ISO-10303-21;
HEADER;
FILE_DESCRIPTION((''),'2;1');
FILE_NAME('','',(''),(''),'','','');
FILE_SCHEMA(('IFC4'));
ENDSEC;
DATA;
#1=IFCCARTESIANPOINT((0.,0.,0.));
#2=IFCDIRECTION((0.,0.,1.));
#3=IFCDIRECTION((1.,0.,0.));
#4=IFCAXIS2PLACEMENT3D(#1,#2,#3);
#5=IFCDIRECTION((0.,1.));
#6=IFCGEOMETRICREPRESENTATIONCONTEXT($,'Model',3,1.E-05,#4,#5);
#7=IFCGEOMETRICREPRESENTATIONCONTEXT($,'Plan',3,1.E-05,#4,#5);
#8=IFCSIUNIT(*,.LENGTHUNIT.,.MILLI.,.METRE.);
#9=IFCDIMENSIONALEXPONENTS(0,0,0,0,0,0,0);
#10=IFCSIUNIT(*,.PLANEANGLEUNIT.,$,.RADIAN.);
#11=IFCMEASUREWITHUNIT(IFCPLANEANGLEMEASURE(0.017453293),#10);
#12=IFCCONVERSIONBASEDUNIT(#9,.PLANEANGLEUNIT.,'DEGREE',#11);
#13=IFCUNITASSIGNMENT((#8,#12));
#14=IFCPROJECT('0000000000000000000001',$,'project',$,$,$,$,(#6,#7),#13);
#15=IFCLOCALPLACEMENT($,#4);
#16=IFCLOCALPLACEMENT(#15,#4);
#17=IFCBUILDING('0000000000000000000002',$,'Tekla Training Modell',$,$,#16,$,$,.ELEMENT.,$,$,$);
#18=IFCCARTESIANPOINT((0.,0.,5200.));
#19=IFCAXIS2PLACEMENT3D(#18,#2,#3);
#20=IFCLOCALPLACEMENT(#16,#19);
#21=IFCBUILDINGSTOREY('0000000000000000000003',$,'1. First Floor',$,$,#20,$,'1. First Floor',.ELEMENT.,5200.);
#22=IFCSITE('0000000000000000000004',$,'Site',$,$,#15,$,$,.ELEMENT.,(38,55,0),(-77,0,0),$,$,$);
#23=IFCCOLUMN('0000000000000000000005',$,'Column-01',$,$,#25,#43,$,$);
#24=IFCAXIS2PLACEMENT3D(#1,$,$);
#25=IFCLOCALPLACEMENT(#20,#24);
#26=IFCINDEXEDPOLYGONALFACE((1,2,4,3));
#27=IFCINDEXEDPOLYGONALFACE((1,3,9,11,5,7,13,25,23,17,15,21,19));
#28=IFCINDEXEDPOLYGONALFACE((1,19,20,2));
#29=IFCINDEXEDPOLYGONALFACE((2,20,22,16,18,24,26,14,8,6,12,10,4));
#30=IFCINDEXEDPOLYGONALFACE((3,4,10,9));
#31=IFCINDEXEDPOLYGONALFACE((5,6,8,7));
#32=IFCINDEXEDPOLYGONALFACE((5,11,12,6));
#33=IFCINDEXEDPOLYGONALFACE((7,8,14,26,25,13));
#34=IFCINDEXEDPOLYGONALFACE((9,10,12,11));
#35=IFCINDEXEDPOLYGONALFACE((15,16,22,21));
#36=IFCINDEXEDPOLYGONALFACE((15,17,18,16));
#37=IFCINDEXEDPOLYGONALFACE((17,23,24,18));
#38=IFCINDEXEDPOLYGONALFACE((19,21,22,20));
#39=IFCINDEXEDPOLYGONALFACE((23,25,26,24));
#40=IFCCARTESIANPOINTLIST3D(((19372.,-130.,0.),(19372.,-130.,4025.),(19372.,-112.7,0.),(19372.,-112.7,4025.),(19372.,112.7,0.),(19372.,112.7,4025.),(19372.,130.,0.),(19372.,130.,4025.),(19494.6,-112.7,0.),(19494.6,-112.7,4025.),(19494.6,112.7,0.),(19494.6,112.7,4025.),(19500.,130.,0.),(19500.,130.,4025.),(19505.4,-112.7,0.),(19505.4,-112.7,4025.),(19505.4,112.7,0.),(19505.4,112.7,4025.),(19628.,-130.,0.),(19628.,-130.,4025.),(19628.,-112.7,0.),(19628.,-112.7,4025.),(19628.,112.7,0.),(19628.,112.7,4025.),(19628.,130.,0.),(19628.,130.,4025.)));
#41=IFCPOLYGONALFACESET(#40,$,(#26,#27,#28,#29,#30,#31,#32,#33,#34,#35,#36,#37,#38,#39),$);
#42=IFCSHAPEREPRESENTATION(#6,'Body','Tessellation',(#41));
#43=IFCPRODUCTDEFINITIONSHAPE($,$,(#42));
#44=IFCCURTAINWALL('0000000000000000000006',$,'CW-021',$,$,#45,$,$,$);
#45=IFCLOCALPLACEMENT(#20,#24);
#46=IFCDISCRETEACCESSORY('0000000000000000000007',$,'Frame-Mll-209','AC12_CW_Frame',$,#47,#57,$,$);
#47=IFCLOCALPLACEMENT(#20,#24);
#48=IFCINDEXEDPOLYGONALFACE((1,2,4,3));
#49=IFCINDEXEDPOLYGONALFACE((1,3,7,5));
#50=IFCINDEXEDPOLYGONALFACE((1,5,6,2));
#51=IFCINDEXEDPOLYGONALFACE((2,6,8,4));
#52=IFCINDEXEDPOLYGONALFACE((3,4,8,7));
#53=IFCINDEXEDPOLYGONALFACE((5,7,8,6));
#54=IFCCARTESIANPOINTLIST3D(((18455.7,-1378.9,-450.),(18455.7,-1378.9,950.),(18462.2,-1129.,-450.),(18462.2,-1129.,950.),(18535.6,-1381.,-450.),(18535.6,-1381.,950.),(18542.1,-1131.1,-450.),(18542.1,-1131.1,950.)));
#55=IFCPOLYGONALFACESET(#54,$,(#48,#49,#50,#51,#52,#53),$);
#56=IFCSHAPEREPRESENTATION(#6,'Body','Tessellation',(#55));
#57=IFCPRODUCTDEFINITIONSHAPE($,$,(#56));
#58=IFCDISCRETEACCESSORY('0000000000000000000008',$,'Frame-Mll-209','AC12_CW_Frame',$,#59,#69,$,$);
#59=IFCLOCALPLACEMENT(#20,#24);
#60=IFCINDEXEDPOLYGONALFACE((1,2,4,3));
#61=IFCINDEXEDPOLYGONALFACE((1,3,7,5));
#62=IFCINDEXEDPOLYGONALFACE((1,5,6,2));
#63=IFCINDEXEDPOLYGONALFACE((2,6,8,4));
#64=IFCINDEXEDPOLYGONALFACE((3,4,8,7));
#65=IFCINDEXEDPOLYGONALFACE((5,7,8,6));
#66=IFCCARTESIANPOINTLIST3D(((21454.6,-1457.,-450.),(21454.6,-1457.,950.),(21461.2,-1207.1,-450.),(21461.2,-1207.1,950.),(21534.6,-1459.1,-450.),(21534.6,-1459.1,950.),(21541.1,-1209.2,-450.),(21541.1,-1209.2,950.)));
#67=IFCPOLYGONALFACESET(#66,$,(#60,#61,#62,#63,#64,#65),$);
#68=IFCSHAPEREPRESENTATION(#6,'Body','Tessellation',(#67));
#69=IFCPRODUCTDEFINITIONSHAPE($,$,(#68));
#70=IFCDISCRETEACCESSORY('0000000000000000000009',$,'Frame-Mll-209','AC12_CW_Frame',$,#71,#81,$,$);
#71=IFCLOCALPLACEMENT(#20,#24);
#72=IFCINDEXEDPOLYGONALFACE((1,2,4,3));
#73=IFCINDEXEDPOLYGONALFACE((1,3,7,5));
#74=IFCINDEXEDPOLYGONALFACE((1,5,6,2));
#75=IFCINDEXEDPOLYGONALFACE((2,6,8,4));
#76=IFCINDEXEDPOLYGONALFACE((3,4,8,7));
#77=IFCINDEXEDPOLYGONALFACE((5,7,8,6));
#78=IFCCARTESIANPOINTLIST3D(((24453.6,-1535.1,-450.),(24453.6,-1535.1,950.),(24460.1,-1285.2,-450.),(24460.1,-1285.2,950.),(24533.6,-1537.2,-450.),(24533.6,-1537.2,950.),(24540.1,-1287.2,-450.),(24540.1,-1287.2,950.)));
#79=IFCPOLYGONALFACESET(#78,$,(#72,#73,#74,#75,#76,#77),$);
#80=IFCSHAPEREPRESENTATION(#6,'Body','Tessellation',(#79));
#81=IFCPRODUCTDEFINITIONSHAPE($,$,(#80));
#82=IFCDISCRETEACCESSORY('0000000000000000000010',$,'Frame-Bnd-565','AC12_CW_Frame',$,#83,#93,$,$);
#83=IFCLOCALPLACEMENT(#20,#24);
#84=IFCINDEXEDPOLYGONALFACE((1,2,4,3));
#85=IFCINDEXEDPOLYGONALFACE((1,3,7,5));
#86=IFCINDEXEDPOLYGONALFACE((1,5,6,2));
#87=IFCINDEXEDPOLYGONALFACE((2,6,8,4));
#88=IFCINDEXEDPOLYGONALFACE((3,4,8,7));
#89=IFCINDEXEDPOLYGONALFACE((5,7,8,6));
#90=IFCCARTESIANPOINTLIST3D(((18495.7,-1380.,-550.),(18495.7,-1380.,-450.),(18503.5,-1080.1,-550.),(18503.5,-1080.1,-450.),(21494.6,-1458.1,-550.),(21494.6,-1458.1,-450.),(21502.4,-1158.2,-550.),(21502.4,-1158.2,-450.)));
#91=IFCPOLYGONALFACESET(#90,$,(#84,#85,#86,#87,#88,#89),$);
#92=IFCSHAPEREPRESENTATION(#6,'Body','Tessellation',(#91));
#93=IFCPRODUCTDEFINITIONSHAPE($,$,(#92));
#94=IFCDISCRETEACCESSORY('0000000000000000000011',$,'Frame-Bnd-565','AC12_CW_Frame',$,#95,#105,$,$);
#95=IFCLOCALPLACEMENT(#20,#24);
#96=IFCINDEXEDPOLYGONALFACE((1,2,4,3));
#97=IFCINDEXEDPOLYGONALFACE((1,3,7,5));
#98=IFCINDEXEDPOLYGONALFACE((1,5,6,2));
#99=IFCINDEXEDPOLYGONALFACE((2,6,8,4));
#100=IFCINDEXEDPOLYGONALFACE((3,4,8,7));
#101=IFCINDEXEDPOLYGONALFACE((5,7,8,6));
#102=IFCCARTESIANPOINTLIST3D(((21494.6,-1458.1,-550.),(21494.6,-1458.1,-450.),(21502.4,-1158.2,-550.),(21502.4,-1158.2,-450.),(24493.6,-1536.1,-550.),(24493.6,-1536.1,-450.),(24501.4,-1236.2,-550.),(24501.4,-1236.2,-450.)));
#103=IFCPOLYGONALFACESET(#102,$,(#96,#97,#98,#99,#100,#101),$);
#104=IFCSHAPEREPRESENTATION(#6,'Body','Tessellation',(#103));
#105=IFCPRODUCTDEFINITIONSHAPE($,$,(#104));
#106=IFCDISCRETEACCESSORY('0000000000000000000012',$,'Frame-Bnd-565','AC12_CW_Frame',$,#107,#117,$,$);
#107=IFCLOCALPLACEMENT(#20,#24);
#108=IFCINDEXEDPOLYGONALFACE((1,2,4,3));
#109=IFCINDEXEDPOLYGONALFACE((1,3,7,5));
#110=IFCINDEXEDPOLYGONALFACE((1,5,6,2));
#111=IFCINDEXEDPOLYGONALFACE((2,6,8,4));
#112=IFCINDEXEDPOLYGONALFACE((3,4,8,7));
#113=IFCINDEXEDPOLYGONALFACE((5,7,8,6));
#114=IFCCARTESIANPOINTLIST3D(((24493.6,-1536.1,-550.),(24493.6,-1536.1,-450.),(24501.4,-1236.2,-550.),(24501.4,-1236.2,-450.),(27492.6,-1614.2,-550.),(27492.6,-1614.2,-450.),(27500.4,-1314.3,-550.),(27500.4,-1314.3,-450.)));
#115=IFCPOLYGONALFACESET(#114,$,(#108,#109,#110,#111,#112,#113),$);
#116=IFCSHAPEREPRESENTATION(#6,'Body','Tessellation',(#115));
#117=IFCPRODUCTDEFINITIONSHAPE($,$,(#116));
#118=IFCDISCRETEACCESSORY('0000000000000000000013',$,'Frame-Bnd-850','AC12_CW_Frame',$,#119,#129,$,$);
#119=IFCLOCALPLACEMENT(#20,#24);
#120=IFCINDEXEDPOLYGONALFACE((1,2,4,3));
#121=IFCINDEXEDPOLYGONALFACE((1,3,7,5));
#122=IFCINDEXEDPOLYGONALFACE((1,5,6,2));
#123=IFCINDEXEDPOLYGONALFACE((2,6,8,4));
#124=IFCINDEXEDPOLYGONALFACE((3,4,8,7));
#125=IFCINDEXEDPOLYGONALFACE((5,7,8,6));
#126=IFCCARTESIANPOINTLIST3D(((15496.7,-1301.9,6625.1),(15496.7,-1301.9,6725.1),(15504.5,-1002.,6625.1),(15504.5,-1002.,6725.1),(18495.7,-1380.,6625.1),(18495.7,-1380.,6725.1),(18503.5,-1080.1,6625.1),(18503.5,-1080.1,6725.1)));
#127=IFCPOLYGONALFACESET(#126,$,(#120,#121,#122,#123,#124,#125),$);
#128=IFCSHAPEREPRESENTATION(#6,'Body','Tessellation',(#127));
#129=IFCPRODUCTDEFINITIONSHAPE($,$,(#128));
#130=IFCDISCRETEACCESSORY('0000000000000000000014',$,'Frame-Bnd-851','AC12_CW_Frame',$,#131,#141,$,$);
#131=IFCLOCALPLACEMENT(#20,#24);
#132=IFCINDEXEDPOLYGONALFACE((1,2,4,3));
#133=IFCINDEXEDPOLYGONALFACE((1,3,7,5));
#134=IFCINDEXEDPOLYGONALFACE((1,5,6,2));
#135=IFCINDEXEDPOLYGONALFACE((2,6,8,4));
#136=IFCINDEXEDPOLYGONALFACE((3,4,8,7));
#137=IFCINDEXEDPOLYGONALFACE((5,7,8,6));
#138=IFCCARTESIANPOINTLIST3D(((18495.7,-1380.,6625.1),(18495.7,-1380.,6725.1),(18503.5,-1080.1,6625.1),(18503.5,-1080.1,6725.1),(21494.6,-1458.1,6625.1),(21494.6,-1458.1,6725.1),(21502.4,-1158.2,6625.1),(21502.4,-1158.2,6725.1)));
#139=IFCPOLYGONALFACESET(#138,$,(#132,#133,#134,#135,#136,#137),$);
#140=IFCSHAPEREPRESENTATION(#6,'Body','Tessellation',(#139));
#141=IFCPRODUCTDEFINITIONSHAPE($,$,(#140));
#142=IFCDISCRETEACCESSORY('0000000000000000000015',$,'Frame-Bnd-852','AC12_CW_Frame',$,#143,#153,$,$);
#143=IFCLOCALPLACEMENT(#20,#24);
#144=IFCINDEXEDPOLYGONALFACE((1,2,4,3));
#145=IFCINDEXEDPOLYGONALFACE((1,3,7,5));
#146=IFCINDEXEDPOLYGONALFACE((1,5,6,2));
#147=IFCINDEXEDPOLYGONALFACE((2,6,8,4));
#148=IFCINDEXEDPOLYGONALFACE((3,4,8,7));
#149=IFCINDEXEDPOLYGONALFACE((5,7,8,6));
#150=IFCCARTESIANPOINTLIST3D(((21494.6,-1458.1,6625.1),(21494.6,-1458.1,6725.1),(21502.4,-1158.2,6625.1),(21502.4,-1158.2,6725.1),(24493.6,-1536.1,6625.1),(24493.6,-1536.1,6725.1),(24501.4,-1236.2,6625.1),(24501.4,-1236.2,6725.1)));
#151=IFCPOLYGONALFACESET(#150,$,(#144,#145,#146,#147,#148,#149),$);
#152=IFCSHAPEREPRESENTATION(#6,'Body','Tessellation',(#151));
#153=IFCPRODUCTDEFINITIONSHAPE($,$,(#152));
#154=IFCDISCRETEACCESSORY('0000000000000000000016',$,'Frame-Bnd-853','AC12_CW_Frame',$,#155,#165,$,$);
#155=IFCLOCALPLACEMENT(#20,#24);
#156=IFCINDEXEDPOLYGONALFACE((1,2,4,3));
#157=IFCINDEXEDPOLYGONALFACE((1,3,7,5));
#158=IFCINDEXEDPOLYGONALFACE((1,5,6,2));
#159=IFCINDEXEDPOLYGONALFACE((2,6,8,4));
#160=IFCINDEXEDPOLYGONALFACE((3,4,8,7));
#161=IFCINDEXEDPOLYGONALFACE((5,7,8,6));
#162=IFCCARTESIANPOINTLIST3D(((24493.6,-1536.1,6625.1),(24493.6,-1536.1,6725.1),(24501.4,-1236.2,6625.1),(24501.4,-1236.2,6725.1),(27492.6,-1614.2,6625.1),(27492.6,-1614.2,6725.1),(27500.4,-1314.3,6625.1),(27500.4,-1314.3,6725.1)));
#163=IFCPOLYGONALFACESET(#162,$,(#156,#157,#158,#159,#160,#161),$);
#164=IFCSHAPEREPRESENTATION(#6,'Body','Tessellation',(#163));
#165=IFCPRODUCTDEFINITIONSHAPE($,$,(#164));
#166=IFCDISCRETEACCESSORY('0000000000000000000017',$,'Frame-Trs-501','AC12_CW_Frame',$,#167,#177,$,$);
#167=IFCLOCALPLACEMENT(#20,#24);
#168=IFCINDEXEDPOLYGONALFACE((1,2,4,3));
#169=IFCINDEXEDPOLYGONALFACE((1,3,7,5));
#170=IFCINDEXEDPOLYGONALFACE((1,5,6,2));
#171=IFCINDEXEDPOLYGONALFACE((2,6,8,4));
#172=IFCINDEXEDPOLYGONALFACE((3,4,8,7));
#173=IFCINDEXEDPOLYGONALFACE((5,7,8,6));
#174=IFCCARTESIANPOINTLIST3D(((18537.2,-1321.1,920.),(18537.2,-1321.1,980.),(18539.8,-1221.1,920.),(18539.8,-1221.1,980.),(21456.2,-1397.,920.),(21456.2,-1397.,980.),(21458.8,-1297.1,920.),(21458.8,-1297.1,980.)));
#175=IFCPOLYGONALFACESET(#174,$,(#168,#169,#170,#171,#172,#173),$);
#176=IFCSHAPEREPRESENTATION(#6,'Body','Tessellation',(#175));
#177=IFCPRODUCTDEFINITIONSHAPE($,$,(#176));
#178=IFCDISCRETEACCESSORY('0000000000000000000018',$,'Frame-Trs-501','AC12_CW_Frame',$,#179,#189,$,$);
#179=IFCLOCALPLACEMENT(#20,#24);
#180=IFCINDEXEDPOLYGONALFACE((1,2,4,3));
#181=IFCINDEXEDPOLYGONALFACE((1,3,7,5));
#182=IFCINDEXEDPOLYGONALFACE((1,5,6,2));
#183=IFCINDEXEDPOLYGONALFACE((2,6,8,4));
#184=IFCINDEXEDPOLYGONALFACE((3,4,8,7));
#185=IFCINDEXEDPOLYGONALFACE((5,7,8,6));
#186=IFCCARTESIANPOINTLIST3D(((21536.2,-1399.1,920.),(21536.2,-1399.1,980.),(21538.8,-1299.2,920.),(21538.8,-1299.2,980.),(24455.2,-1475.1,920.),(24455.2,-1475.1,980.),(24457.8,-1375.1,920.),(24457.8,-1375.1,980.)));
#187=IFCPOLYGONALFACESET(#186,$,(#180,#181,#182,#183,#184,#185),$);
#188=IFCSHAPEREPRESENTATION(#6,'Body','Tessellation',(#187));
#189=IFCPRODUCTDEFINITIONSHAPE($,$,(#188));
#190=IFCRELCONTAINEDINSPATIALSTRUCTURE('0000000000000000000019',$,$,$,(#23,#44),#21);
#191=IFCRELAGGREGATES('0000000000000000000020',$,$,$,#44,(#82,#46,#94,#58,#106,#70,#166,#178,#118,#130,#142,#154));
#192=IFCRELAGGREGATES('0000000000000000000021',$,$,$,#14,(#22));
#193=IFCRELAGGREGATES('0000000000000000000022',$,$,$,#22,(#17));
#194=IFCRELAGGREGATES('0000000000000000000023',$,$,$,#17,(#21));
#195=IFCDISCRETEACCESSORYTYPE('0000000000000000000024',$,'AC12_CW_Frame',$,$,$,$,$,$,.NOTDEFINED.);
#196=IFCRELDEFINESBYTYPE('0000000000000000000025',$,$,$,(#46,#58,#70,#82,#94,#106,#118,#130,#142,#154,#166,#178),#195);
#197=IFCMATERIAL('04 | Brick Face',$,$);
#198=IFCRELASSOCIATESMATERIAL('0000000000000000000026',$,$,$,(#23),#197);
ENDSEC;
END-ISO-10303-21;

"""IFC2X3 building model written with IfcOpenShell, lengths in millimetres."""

from ifc_helpers import new_model, entity, si_unit, converted_unit, direction, frame, origin_with_axes, place, context, project, spatial, polyline, outline, extrude, source, transform, mapped, material, type_object, element, aggregate, save


model = new_model("IFC2X3")

# Units and contexts
model_context = context("Model", 3, precision=1e-05, world=origin_with_axes(), true_north=direction((0.0, 1.0)))
plan_context = context("Plan", 3, precision=1e-05, world=origin_with_axes(), true_north=direction((0.0, 1.0)))
ifc_project = project(units=[si_unit("LENGTHUNIT", "METRE", prefix="MILLI"), converted_unit("PLANEANGLEUNIT", "DEGREE", entity("IfcPlaneAngleMeasure", 0.017453293), si_unit("PLANEANGLEUNIT", "RADIAN"), dimensions=[0, 0, 0, 0, 0, 0, 0])], contexts=[model_context, plan_context])

# Site, building, storey
site_placement = place(None, origin_with_axes())
site = spatial("IfcSite", under=ifc_project, at=site_placement, Name="Site", CompositionType="ELEMENT", RefLatitude=(38, 55, 0), RefLongitude=(-77, 0, 0))
building_placement = place(site_placement, origin_with_axes())
building = spatial("IfcBuilding", under=site, at=building_placement, Name="Tekla Training Modell", CompositionType="ELEMENT")
storey_placement = place(building_placement, frame((0.0, 0.0, 5200.0), z_axis=(0.0, 0.0, 1.0), x_axis=(1.0, 0.0, 0.0)))
storey = spatial("IfcBuildingStorey", under=building, at=storey_placement, Name="1. First Floor", LongName="1. First Floor", CompositionType="ELEMENT", Elevation=5200.0)

# Column
ifc_material = material(Name="04 | Brick Face")
column_placement = place(storey_placement, frame((19500.0, 0.0, 0.0), z_axis=(0.0, 0.0, 1.0), x_axis=(1.0, 0.0, 0.0)))
element("IfcColumn", 1, at=column_placement, inside=storey, material=ifc_material, Name="Column-01", context=model_context, shape_type="SweptSolid", body=[
    extrude(outline(polyline([(0.0, 130.0), (-128.0, 130.0), (-128.0, 112.7), (-5.3, 112.7), (-5.3, -112.7), (-128.0, -112.7), (-128.0, -130.0), (128.0, -130.0), (128.0, -112.7), (5.3, -112.7), (5.3, 112.7), (128.0, 112.7), (128.0, 130.0), (0.0, 130.0)])), origin_with_axes(), (0.0, 0.0, 1.0), 4025.0),
])

# Curtain wall, discrete accessories
curtain_wall_placement = place(storey_placement, frame((9500.0, -1095.8, -550.0), z_axis=(0.0, 0.0, 1.0), x_axis=(0.999661, -0.026022, 0.0)))
curtain_wall = element("IfcCurtainWall", 2, at=curtain_wall_placement, inside=storey, Name="CW-021")
discrete_accessory_type = type_object("IfcDiscreteAccessoryType", Name="AC12_CW_Frame")
shared_shape_1 = source(origin_with_axes(), model_context, "Body", "SweptSolid", [
    extrude(outline(polyline([(0.0, 0.0), (250.0, 0.0), (250.0, -1400.0), (0.0, -1400.0), (0.0, 0.0)])), origin_with_axes(), (0.0, 0.0, 1.0), 80.0),
])
discrete_accessory_1_placement = place(storey_placement, frame((18462.2, -1129.0, -450.0), z_axis=(0.999661, -0.026022, 0.0), x_axis=(-0.026022, -0.999661, 0.0)))
discrete_accessory_1 = element("IfcDiscreteAccessory", 3, at=discrete_accessory_1_placement, type_object=discrete_accessory_type, Name="Frame-Mll-209", Description="AC12_CW_Frame", context=model_context, shape_type="MappedRepresentation", body=[
    mapped(shared_shape_1, transform((0.0, 0.0, 0.0), scale=1.0)),
])
discrete_accessory_2_placement = place(storey_placement, frame((21461.2, -1207.1, -450.0), z_axis=(0.999661, -0.026022, 0.0), x_axis=(-0.026022, -0.999661, 0.0)))
discrete_accessory_2 = element("IfcDiscreteAccessory", 4, at=discrete_accessory_2_placement, type_object=discrete_accessory_type, Name="Frame-Mll-209", Description="AC12_CW_Frame", context=model_context, shape_type="MappedRepresentation", body=[
    mapped(shared_shape_1, transform((0.0, 0.0, 0.0), scale=1.0)),
])
discrete_accessory_3_placement = place(storey_placement, frame((24460.1, -1285.2, -450.0), z_axis=(0.999661, -0.026022, 0.0), x_axis=(-0.026022, -0.999661, 0.0)))
discrete_accessory_3 = element("IfcDiscreteAccessory", 5, at=discrete_accessory_3_placement, type_object=discrete_accessory_type, Name="Frame-Mll-209", Description="AC12_CW_Frame", context=model_context, shape_type="MappedRepresentation", body=[
    mapped(shared_shape_1, transform((0.0, 0.0, 0.0), scale=1.0)),
])
shared_shape_2 = source(origin_with_axes(), model_context, "Body", "SweptSolid", [
    extrude(outline(polyline([(0.0, 0.0), (300.0, 0.0), (300.0, -3000.0), (0.0, -3000.0), (0.0, 0.0)])), origin_with_axes(), (0.0, 0.0, 1.0), 100.0),
])
discrete_accessory_4_placement = place(storey_placement, frame((18503.5, -1080.1, -450.0), z_axis=(0.0, 0.0, -1.0), x_axis=(-0.026022, -0.999661, 0.0)))
discrete_accessory_4 = element("IfcDiscreteAccessory", 6, at=discrete_accessory_4_placement, type_object=discrete_accessory_type, Name="Frame-Bnd-565", Description="AC12_CW_Frame", context=model_context, shape_type="MappedRepresentation", body=[
    mapped(shared_shape_2, transform((0.0, 0.0, 0.0), scale=1.0)),
])
discrete_accessory_5_placement = place(storey_placement, frame((21502.4, -1158.2, -450.0), z_axis=(0.0, 0.0, -1.0), x_axis=(-0.026022, -0.999661, 0.0)))
discrete_accessory_5 = element("IfcDiscreteAccessory", 7, at=discrete_accessory_5_placement, type_object=discrete_accessory_type, Name="Frame-Bnd-565", Description="AC12_CW_Frame", context=model_context, shape_type="MappedRepresentation", body=[
    mapped(shared_shape_2, transform((0.0, 0.0, 0.0), scale=1.0)),
])
discrete_accessory_6_placement = place(storey_placement, frame((24501.4, -1236.2, -450.0), z_axis=(0.0, 0.0, -1.0), x_axis=(-0.026022, -0.999661, 0.0)))
discrete_accessory_6 = element("IfcDiscreteAccessory", 8, at=discrete_accessory_6_placement, type_object=discrete_accessory_type, Name="Frame-Bnd-565", Description="AC12_CW_Frame", context=model_context, shape_type="MappedRepresentation", body=[
    mapped(shared_shape_2, transform((0.0, 0.0, 0.0), scale=1.0)),
])
discrete_accessory_7_placement = place(storey_placement, frame((18503.5, -1080.1, 6625.1), z_axis=(0.0, 0.0, 1.0), x_axis=(-0.026022, -0.999661, 0.0)))
discrete_accessory_7 = element("IfcDiscreteAccessory", 9, at=discrete_accessory_7_placement, type_object=discrete_accessory_type, Name="Frame-Bnd-850", Description="AC12_CW_Frame", context=model_context, shape_type="MappedRepresentation", body=[
    mapped(shared_shape_2, transform((0.0, 0.0, 0.0), scale=1.0)),
])
discrete_accessory_8_placement = place(storey_placement, frame((21502.4, -1158.2, 6625.1), z_axis=(0.0, 0.0, 1.0), x_axis=(-0.026022, -0.999661, 0.0)))
discrete_accessory_8 = element("IfcDiscreteAccessory", 10, at=discrete_accessory_8_placement, type_object=discrete_accessory_type, Name="Frame-Bnd-851", Description="AC12_CW_Frame", context=model_context, shape_type="MappedRepresentation", body=[
    mapped(shared_shape_2, transform((0.0, 0.0, 0.0), scale=1.0)),
])
discrete_accessory_9_placement = place(storey_placement, frame((24501.4, -1236.2, 6625.1), z_axis=(0.0, 0.0, 1.0), x_axis=(-0.026022, -0.999661, 0.0)))
discrete_accessory_9 = element("IfcDiscreteAccessory", 11, at=discrete_accessory_9_placement, type_object=discrete_accessory_type, Name="Frame-Bnd-852", Description="AC12_CW_Frame", context=model_context, shape_type="MappedRepresentation", body=[
    mapped(shared_shape_2, transform((0.0, 0.0, 0.0), scale=1.0)),
])
discrete_accessory_10_placement = place(storey_placement, frame((27500.4, -1314.3, 6625.1), z_axis=(0.0, 0.0, 1.0), x_axis=(-0.026022, -0.999661, 0.0)))
discrete_accessory_10 = element("IfcDiscreteAccessory", 12, at=discrete_accessory_10_placement, type_object=discrete_accessory_type, Name="Frame-Bnd-853", Description="AC12_CW_Frame", context=model_context, shape_type="MappedRepresentation", body=[
    mapped(shared_shape_2, transform((0.0, 0.0, 0.0), scale=1.0)),
])
shared_shape_3 = source(origin_with_axes(), model_context, "Body", "SweptSolid", [
    extrude(outline(polyline([(0.0, 0.0), (100.0, 0.0), (100.0, -2920.0), (0.0, -2920.0), (0.0, 0.0)])), origin_with_axes(), (0.0, 0.0, 1.0), 60.0),
])
discrete_accessory_11_placement = place(storey_placement, frame((18539.8, -1221.1, 980.0), z_axis=(0.0, 0.0, -1.0), x_axis=(-0.026022, -0.999661, 0.0)))
discrete_accessory_11 = element("IfcDiscreteAccessory", 13, at=discrete_accessory_11_placement, type_object=discrete_accessory_type, Name="Frame-Trs-501", Description="AC12_CW_Frame", context=model_context, shape_type="MappedRepresentation", body=[
    mapped(shared_shape_3, transform((0.0, 0.0, 0.0), scale=1.0)),
])
discrete_accessory_12_placement = place(storey_placement, frame((21538.8, -1299.2, 980.0), z_axis=(0.0, 0.0, -1.0), x_axis=(-0.026022, -0.999661, 0.0)))
discrete_accessory_12 = element("IfcDiscreteAccessory", 14, at=discrete_accessory_12_placement, type_object=discrete_accessory_type, Name="Frame-Trs-501", Description="AC12_CW_Frame", context=model_context, shape_type="MappedRepresentation", body=[
    mapped(shared_shape_3, transform((0.0, 0.0, 0.0), scale=1.0)),
])
aggregate(curtain_wall, [discrete_accessory_4, discrete_accessory_1, discrete_accessory_5, discrete_accessory_2, discrete_accessory_6, discrete_accessory_3, discrete_accessory_11, discrete_accessory_12, discrete_accessory_7, discrete_accessory_8, discrete_accessory_9, discrete_accessory_10])

save(model, "model.ifc")
